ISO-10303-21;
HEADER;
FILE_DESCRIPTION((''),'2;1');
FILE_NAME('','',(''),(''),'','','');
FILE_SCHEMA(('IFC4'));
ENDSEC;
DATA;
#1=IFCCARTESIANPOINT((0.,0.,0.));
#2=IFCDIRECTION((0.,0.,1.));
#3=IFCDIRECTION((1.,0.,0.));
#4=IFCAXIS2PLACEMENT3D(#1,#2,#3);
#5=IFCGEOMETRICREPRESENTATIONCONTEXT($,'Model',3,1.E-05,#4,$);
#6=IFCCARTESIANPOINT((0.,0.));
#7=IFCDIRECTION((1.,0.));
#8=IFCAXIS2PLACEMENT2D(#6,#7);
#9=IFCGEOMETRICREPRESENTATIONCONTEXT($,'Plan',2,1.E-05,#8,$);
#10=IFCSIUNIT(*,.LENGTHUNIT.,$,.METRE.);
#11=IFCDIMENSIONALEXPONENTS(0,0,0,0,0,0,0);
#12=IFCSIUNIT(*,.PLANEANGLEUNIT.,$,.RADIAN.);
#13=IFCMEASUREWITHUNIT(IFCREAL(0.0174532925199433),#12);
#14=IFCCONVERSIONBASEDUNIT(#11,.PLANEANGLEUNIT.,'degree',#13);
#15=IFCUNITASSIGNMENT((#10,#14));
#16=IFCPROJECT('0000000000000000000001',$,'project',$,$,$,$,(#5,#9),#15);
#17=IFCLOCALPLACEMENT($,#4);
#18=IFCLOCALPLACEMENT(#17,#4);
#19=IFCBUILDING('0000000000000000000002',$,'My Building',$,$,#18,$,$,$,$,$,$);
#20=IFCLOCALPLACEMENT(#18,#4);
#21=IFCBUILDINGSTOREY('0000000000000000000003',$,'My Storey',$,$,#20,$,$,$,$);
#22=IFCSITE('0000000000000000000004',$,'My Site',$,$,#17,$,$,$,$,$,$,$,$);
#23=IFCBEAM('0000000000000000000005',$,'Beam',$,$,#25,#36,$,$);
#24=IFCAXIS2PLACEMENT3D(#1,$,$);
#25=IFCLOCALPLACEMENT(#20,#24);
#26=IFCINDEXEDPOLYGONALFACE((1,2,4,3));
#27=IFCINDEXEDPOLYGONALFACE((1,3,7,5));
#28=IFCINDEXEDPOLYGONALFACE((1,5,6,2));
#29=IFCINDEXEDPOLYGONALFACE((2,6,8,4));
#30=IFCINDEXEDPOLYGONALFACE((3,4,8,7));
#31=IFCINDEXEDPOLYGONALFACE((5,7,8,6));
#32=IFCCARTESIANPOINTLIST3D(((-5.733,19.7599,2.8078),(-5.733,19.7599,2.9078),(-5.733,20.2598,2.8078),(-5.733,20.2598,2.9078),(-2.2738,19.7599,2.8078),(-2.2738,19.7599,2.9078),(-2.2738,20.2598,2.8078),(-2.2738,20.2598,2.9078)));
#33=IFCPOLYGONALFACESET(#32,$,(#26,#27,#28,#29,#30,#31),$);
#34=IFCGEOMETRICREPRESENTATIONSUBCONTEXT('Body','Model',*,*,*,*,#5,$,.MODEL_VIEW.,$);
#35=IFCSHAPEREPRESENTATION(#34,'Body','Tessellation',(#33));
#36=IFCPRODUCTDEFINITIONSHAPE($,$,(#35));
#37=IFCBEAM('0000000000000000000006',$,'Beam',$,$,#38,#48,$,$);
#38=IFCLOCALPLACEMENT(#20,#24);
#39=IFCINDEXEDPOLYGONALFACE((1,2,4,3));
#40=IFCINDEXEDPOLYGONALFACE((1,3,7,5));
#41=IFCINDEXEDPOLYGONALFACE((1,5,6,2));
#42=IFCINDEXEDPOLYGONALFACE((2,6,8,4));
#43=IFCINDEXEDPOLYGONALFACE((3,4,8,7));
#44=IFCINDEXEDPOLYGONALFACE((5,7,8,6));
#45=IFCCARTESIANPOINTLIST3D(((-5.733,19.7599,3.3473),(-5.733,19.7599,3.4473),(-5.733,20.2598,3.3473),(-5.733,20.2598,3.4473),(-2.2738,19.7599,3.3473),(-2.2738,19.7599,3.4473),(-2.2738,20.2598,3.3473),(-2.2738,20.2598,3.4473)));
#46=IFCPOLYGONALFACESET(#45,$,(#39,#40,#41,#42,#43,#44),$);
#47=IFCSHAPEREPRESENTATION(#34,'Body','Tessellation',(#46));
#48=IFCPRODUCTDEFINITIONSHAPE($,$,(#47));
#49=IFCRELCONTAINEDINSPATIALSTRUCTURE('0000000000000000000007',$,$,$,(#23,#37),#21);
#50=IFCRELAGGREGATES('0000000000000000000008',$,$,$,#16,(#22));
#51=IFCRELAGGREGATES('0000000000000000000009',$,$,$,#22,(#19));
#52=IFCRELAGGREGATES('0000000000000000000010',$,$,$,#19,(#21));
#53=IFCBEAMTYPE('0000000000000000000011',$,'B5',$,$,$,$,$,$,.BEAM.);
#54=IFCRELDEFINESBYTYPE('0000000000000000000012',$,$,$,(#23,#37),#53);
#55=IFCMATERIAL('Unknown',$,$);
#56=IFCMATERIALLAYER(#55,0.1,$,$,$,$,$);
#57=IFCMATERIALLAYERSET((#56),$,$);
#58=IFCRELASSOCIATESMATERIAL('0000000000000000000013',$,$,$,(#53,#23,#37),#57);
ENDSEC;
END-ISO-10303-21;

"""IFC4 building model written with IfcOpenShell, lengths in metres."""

from ifc_helpers import new_model, entity, si_unit, converted_unit, frame, origin_with_axes, origin_2d_with_axis, place, context, subcontext, project, spatial, indexed_curve, outline, extrude, material, layer, layer_set, layer_usage, type_object, element, save


model = new_model("IFC4")

# Units and contexts
model_context = context("Model", 3, precision=1e-05, world=origin_with_axes())
plan_context = context("Plan", 2, precision=1e-05, world=origin_2d_with_axis())
body_context = subcontext(model_context, "Body", "Model", "MODEL_VIEW")
ifc_project = project(units=[si_unit("LENGTHUNIT", "METRE"), converted_unit("PLANEANGLEUNIT", "degree", entity("IfcReal", 0.0174532925199433), si_unit("PLANEANGLEUNIT", "RADIAN"), dimensions=[0, 0, 0, 0, 0, 0, 0])], contexts=[model_context, plan_context])

# Site, building, storey
site_placement = place(None, origin_with_axes())
site = spatial("IfcSite", under=ifc_project, at=site_placement, Name="My Site")
building_placement = place(site_placement, origin_with_axes())
building = spatial("IfcBuilding", under=site, at=building_placement, Name="My Building")
storey_placement = place(building_placement, origin_with_axes())
storey = spatial("IfcBuildingStorey", under=building, at=storey_placement, Name="My Storey")

# Shared definitions
ifc_material = material(Name="Unknown")

# Beams
ifc_layer_1 = layer(ifc_material, 0.1)
ifc_layer_set_1 = layer_set([ifc_layer_1])
beam_type_1 = type_object("IfcBeamType", Name="B5", PredefinedType="BEAM", material=ifc_layer_set_1)
ifc_layer_usage_1 = layer_usage(ifc_layer_set_1, "AXIS3", "POSITIVE", -0.1)
beam_1_placement = place(storey_placement, frame((-2.2738, 20.2598, 2.9078), z_axis=(0.0, 0.0, 1.0), x_axis=(1.0, 0.0, 0.0)))
element("IfcBeam", 1, at=beam_1_placement, inside=storey, type_object=beam_type_1, material=ifc_layer_usage_1, Name="Beam", context=body_context, shape_type="SweptSolid", body=[
    extrude(outline(indexed_curve([(0.0, 0.0), (0.0, -0.5), (-3.4592, -0.5), (-3.4592, 0.0), (0.0, 0.0), (0.0, 0.0)])), frame((0.0, 0.0, -0.1), z_axis=(0.0, 0.0, 1.0), x_axis=(1.0, 0.0, 0.0)), (0.0, 0.0, 1.0), 0.1),
])
ifc_layer_usage_2 = layer_usage(ifc_layer_set_1, "AXIS3", "POSITIVE", -0.1)
beam_2_placement = place(storey_placement, frame((-2.2738, 20.2598, 3.4473), z_axis=(0.0, 0.0, 1.0), x_axis=(1.0, 0.0, 0.0)))
element("IfcBeam", 2, at=beam_2_placement, inside=storey, type_object=beam_type_1, material=ifc_layer_usage_2, Name="Beam", context=body_context, shape_type="SweptSolid", body=[
    extrude(outline(indexed_curve([(0.0, 0.0), (0.0, -0.5), (-3.4592, -0.5), (-3.4592, 0.0), (0.0, 0.0), (0.0, 0.0)])), frame((0.0, 0.0, -0.1), z_axis=(0.0, 0.0, 1.0), x_axis=(1.0, 0.0, 0.0)), (0.0, 0.0, 1.0), 0.1),
])

save(model, "model.ifc")
